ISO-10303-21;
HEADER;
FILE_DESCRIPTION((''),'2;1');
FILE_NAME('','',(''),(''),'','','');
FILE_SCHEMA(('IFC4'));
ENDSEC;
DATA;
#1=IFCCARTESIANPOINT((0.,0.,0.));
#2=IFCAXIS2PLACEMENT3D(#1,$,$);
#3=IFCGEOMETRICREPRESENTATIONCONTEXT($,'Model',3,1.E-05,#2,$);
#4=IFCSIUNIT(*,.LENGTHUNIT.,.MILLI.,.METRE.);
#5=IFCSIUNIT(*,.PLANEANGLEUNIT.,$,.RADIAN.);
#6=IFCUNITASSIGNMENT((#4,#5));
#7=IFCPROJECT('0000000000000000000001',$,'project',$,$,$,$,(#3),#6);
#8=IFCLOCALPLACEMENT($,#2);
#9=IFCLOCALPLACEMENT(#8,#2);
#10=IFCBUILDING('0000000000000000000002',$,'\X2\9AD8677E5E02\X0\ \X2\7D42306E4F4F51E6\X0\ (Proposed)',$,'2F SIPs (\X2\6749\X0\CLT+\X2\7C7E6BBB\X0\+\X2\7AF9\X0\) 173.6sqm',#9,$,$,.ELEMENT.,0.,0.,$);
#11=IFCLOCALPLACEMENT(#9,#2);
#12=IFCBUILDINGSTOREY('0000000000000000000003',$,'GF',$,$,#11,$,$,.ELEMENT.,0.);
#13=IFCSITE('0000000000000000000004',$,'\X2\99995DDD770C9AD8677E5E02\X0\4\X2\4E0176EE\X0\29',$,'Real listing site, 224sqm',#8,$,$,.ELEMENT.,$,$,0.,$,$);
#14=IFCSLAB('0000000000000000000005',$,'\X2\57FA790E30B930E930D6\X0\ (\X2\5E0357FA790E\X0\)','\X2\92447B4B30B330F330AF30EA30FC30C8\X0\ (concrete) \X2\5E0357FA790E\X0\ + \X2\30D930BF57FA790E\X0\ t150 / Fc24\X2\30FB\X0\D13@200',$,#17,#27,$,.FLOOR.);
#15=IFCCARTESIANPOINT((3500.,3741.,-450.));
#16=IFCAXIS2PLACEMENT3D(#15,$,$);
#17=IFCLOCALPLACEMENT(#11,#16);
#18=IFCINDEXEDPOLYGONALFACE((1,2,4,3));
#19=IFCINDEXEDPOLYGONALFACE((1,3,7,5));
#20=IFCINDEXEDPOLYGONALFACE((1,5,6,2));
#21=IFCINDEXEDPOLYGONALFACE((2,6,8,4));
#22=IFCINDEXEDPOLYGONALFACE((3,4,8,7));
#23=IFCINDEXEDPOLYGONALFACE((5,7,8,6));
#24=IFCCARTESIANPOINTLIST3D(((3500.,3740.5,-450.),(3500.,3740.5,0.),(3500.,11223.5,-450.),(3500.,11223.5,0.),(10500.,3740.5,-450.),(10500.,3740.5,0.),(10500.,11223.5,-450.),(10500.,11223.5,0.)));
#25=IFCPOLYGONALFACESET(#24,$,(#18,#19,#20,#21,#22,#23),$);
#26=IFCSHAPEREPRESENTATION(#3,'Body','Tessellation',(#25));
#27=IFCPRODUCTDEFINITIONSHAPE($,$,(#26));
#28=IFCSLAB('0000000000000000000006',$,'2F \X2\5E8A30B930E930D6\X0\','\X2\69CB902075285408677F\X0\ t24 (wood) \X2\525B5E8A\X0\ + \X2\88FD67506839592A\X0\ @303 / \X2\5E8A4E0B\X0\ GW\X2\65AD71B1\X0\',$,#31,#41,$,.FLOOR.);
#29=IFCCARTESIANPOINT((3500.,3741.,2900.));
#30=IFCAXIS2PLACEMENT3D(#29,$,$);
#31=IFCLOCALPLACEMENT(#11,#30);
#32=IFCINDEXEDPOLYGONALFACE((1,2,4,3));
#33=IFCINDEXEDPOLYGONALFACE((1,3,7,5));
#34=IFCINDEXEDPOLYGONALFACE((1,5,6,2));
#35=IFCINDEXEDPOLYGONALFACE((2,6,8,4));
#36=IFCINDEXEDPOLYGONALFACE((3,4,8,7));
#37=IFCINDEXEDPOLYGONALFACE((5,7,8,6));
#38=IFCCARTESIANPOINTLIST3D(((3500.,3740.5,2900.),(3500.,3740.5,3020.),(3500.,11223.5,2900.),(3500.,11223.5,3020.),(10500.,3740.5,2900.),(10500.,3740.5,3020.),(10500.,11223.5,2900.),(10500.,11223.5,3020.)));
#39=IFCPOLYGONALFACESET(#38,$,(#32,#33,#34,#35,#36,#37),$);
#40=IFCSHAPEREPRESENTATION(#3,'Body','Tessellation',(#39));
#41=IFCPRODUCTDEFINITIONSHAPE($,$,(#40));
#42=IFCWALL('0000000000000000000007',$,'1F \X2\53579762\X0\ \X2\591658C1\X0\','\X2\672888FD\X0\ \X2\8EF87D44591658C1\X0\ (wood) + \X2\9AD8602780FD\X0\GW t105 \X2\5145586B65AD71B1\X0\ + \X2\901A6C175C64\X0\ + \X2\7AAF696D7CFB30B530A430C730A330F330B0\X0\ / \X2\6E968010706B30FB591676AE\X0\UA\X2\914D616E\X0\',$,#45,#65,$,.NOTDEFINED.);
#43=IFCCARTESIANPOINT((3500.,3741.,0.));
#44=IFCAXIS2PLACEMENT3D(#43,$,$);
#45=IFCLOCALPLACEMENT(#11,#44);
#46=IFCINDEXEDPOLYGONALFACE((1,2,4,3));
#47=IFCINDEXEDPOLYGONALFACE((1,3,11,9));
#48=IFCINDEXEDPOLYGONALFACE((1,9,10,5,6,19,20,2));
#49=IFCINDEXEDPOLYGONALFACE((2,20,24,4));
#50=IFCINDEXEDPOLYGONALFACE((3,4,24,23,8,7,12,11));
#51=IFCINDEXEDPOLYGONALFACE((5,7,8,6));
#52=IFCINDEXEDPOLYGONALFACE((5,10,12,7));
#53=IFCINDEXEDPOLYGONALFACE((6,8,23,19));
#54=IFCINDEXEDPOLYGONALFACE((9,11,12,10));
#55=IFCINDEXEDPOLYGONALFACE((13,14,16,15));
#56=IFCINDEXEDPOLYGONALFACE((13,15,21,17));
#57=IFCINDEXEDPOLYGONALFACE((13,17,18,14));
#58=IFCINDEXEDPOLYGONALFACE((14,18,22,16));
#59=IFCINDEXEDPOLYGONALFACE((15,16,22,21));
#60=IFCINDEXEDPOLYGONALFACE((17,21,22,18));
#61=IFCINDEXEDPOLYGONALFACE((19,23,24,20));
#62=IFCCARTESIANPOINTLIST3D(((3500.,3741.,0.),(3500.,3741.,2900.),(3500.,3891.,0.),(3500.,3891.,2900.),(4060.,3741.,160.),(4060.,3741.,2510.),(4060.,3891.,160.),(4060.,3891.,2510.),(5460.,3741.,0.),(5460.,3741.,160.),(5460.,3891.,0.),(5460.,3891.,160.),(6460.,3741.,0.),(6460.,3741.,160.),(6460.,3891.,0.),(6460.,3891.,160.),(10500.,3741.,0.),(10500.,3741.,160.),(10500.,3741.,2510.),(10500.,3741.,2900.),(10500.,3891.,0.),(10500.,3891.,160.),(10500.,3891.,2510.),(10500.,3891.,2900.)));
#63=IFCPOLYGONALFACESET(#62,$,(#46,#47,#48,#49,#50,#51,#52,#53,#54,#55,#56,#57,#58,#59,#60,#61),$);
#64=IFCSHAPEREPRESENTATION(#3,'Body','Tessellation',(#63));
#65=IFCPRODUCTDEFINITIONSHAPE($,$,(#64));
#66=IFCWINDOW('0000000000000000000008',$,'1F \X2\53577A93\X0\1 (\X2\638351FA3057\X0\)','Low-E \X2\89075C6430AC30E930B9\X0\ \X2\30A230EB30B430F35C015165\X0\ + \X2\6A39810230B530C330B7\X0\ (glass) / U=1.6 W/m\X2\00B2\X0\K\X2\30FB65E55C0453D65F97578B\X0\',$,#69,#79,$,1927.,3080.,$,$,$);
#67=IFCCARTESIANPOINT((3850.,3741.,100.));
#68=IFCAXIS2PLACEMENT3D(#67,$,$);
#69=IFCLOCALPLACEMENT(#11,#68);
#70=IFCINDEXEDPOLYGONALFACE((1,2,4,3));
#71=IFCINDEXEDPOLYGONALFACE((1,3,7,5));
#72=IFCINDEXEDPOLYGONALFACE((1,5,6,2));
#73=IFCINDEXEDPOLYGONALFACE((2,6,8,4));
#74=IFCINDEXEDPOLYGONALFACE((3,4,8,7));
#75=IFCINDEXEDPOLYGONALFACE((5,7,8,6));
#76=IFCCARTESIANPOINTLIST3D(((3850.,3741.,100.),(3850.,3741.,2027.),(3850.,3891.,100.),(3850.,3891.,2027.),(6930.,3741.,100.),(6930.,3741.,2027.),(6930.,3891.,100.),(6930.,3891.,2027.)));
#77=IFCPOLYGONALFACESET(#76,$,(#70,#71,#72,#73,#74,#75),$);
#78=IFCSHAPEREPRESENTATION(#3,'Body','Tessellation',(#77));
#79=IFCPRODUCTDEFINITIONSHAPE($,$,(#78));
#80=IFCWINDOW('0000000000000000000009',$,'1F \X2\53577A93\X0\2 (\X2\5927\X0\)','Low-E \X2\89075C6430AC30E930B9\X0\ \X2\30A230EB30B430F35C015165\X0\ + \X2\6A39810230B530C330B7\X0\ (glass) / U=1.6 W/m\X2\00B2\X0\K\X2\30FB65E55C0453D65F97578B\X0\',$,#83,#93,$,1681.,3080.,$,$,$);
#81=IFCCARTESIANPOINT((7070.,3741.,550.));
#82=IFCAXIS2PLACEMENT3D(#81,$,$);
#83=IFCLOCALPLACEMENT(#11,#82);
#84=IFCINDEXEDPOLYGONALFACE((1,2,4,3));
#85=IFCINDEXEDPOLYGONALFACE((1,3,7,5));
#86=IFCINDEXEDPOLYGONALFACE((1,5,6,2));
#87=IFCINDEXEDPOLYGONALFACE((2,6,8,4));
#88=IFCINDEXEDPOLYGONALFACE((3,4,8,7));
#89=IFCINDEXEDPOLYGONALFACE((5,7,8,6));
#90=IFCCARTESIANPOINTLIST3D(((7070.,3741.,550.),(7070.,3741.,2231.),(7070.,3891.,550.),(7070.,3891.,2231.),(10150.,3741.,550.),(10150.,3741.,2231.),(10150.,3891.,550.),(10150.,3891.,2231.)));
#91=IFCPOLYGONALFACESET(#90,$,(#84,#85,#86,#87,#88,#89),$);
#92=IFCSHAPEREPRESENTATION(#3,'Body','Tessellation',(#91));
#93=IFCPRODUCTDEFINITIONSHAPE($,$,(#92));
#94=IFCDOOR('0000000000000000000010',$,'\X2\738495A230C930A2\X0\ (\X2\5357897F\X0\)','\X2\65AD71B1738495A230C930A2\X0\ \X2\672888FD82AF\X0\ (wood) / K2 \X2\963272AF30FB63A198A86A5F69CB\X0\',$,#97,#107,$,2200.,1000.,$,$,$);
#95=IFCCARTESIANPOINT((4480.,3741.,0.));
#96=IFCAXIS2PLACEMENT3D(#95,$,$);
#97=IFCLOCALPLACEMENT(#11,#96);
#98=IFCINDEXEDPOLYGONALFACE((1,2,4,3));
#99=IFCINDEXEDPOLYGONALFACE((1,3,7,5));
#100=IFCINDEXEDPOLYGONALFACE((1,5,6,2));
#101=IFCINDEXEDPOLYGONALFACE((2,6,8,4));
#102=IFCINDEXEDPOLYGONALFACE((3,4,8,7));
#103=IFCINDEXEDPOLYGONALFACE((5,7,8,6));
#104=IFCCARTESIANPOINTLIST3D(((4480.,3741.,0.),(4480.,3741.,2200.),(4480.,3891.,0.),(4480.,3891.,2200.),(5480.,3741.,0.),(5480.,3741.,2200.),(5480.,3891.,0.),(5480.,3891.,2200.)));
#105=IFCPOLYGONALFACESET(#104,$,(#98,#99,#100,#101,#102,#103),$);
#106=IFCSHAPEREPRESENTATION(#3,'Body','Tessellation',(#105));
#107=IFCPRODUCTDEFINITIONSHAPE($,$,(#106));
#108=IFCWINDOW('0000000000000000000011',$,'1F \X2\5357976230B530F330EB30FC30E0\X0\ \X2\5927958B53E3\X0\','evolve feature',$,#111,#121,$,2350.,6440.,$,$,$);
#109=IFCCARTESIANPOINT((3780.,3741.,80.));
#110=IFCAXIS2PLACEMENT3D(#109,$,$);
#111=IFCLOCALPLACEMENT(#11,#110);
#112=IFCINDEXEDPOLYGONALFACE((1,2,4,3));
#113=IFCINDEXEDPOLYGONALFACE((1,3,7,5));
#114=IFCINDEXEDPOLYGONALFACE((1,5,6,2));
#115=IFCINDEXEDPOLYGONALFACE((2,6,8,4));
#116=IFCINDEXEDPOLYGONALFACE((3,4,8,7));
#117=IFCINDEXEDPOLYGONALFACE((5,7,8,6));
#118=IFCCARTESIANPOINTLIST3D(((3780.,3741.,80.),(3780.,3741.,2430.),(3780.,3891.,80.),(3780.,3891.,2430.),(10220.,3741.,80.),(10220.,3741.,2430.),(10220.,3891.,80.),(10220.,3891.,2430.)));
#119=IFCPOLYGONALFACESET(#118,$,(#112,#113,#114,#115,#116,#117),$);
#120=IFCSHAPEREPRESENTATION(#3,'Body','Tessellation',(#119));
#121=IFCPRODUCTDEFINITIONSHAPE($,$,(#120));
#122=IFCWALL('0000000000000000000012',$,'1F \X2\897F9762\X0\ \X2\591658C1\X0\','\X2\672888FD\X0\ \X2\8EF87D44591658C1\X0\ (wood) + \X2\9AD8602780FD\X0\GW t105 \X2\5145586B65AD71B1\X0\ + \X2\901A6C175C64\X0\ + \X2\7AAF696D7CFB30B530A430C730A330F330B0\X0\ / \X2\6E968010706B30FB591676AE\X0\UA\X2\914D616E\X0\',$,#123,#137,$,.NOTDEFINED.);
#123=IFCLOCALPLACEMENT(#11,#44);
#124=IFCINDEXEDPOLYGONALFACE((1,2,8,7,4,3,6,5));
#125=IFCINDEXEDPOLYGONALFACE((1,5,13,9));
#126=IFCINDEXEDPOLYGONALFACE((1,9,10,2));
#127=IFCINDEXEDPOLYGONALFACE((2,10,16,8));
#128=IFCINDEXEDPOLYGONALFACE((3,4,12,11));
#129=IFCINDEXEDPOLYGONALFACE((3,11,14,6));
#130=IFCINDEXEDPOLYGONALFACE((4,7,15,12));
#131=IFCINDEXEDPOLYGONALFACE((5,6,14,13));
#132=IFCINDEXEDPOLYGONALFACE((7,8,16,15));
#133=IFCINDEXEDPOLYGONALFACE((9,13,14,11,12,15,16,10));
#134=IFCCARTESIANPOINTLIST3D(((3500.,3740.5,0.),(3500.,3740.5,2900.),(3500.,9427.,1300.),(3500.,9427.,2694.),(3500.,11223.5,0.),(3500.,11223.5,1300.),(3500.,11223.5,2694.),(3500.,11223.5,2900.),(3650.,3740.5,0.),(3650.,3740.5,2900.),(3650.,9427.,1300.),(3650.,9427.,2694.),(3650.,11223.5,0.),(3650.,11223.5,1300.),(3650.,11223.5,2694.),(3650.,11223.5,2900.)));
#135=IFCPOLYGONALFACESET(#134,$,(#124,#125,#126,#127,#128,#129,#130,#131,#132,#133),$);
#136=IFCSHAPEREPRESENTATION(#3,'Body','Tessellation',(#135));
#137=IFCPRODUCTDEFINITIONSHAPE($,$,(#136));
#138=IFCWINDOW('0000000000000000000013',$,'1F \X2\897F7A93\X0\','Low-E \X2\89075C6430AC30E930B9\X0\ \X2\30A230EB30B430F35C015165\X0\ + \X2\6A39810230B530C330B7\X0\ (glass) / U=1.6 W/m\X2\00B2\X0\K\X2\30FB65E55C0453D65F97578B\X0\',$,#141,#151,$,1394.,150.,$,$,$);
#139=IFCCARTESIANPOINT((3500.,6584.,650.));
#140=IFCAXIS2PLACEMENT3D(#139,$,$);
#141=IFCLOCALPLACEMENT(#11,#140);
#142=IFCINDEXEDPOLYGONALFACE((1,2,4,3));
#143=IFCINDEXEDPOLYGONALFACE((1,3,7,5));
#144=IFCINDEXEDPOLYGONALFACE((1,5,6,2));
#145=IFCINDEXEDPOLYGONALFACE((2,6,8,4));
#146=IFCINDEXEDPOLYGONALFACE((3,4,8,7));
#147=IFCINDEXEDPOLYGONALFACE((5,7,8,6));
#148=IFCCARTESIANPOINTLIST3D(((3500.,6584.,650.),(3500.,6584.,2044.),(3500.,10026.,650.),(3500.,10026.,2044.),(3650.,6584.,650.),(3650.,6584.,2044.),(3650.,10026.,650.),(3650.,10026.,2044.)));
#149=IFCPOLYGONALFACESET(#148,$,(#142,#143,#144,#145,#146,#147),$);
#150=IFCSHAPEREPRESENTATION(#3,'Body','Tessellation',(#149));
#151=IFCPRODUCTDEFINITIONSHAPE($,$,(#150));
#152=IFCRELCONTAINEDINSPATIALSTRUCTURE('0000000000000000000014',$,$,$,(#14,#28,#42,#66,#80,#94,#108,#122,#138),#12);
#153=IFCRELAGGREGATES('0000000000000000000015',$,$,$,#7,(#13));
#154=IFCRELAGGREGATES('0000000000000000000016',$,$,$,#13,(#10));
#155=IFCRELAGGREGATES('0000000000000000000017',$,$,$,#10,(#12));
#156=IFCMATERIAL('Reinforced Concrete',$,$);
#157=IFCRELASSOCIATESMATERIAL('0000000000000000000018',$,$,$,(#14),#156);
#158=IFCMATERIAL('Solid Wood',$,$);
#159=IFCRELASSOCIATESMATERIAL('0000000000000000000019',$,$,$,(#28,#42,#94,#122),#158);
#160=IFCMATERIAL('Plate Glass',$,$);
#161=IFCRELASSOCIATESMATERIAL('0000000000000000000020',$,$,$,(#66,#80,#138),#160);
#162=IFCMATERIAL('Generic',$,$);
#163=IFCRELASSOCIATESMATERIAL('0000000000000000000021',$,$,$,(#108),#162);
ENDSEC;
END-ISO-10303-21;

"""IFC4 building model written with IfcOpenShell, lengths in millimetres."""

from ifc_helpers import new_model, si_unit, frame, frame_2d, origin, place, context, project, spatial, rectangle, extrude, material, element, fill, save


model = new_model("IFC4")

# Units and contexts
model_context = context("Model", 3, precision=1e-05, world=origin())
ifc_project = project(units=[si_unit("LENGTHUNIT", "METRE", prefix="MILLI"), si_unit("PLANEANGLEUNIT", "RADIAN")], contexts=[model_context])

# Site, building, storey
site_placement = place(None, origin())
site = spatial("IfcSite", under=ifc_project, at=site_placement, Name="香川県高松市4丁目29", ObjectType="Real listing site, 224sqm", CompositionType="ELEMENT", RefElevation=0.0)
building_placement = place(site_placement, origin())
building = spatial("IfcBuilding", under=site, at=building_placement, Name="高松市 終の住処 (Proposed)", ObjectType="2F SIPs (杉CLT+籾殻+竹) 173.6sqm", CompositionType="ELEMENT", ElevationOfRefHeight=0.0, ElevationOfTerrain=0.0)
storey_placement = place(building_placement, origin())
storey = spatial("IfcBuildingStorey", under=building, at=storey_placement, Name="GF", CompositionType="ELEMENT", Elevation=0.0)

# Slabs
ifc_material_1 = material(Name="Reinforced Concrete")
slab_1_placement = place(storey_placement, frame((3500.0, 3741.0, -450.0)))
element("IfcSlab", 1, at=slab_1_placement, inside=storey, material=ifc_material_1, Name="基礎スラブ (布基礎)", Description="鉄筋コンクリート (concrete) 布基礎 + ベタ基礎 t150 / Fc24・D13@200", PredefinedType="FLOOR", context=model_context, shape_type="SweptSolid", body=[
    extrude(rectangle(XDim=7000.0, YDim=7483.0, at=frame_2d((3500.0, 3741.0))), frame((3500.0, 3741.0, -450.0)), (0.0, 0.0, 1.0), 450.0),
])
ifc_material_2 = material(Name="Solid Wood")
slab_2_placement = place(storey_placement, frame((3500.0, 3741.0, 2900.0)))
element("IfcSlab", 2, at=slab_2_placement, inside=storey, material=ifc_material_2, Name="2F 床スラブ", Description="構造用合板 t24 (wood) 剛床 + 製材根太 @303 / 床下 GW断熱", PredefinedType="FLOOR", context=model_context, shape_type="SweptSolid", body=[
    extrude(rectangle(XDim=7000.0, YDim=7483.0, at=frame_2d((3500.0, 3741.0))), frame((3500.0, 3741.0, 2900.0)), (0.0, 0.0, 1.0), 120.0),
])
ifc_material_3 = material(Name="Generic")

# Wall, openings, windows, door
wall_1_placement = place(storey_placement, frame((3500.0, 3741.0, 0.0)))
wall_1 = element("IfcWall", 3, at=wall_1_placement, inside=storey, material=ifc_material_2, Name="1F 南面 外壁", Description="木製 軸組外壁 (wood) + 高性能GW t105 充填断熱 + 通気層 + 窯業系サイディング / 準耐火・外皮UA配慮", PredefinedType="NOTDEFINED", context=model_context, shape_type="SweptSolid", body=[
    extrude(rectangle(XDim=7000.0, YDim=150.0, at=frame_2d((3500.0, 75.0))), frame((3500.0, 3741.0, 0.0)), (0.0, 0.0, 1.0), 2900.0),
])
opening_1_placement = place(storey_placement, frame((3850.0, 3741.0, 100.0)))
opening_1 = element("IfcOpeningElement", 4, at=opening_1_placement, cuts=wall_1, PredefinedType="NOTDEFINED", context=model_context, shape_type="SweptSolid", body=[
    extrude(rectangle(XDim=3080.0, YDim=150.0, at=frame_2d((1540.0, 75.0))), frame((3850.0, 3741.0, 100.0)), (0.0, 0.0, 1.0), 1927.0),
])
opening_2_placement = place(storey_placement, frame((7070.0, 3741.0, 550.0)))
opening_2 = element("IfcOpeningElement", 5, at=opening_2_placement, cuts=wall_1, PredefinedType="NOTDEFINED", context=model_context, shape_type="SweptSolid", body=[
    extrude(rectangle(XDim=3080.0, YDim=150.0, at=frame_2d((1540.0, 75.0))), frame((7070.0, 3741.0, 550.0)), (0.0, 0.0, 1.0), 1681.0),
])
opening_3_placement = place(storey_placement, frame((4480.0, 3741.0, 0.0)))
opening_3 = element("IfcOpeningElement", 6, at=opening_3_placement, cuts=wall_1, PredefinedType="NOTDEFINED", context=model_context, shape_type="SweptSolid", body=[
    extrude(rectangle(XDim=1000.0, YDim=150.0, at=frame_2d((500.0, 75.0))), frame((4480.0, 3741.0, 0.0)), (0.0, 0.0, 1.0), 2200.0),
])
opening_4_placement = place(storey_placement, frame((3780.0, 3741.0, 80.0)))
opening_4 = element("IfcOpeningElement", 7, at=opening_4_placement, cuts=wall_1, PredefinedType="NOTDEFINED", context=model_context, shape_type="SweptSolid", body=[
    extrude(rectangle(XDim=6440.0, YDim=150.0, at=frame_2d((3220.0, 75.0))), frame((3780.0, 3741.0, 80.0)), (0.0, 0.0, 1.0), 2350.0),
])
ifc_material_4 = material(Name="Plate Glass")
window_1_placement = place(storey_placement, frame((3850.0, 3741.0, 100.0)))
window_1 = element("IfcWindow", 8, at=window_1_placement, inside=storey, material=ifc_material_4, Name="1F 南窓1 (掃出し)", Description="Low-E 複層ガラス アルゴン封入 + 樹脂サッシ (glass) / U=1.6 W/m²K・日射取得型", OverallHeight=1927.0, OverallWidth=3080.0, context=model_context, shape_type="SweptSolid", body=[
    extrude(rectangle(XDim=3080.0, YDim=150.0, at=frame_2d((1540.0, 75.0))), frame((3850.0, 3741.0, 100.0)), (0.0, 0.0, 1.0), 1927.0),
])
fill(opening_1, window_1)
window_2_placement = place(storey_placement, frame((7070.0, 3741.0, 550.0)))
window_2 = element("IfcWindow", 9, at=window_2_placement, inside=storey, material=ifc_material_4, Name="1F 南窓2 (大)", Description="Low-E 複層ガラス アルゴン封入 + 樹脂サッシ (glass) / U=1.6 W/m²K・日射取得型", OverallHeight=1681.0, OverallWidth=3080.0, context=model_context, shape_type="SweptSolid", body=[
    extrude(rectangle(XDim=3080.0, YDim=150.0, at=frame_2d((1540.0, 75.0))), frame((7070.0, 3741.0, 550.0)), (0.0, 0.0, 1.0), 1681.0),
])
fill(opening_2, window_2)
door_placement = place(storey_placement, frame((4480.0, 3741.0, 0.0)))
door = element("IfcDoor", 10, at=door_placement, inside=storey, material=ifc_material_2, Name="玄関ドア (南西)", Description="断熱玄関ドア 木製芯 (wood) / K2 防犯・採風機構", OverallHeight=2200.0, OverallWidth=1000.0, context=model_context, shape_type="SweptSolid", body=[
    extrude(rectangle(XDim=1000.0, YDim=150.0, at=frame_2d((500.0, 75.0))), frame((4480.0, 3741.0, 0.0)), (0.0, 0.0, 1.0), 2200.0),
])
fill(opening_3, door)
window_3_placement = place(storey_placement, frame((3780.0, 3741.0, 80.0)))
window_3 = element("IfcWindow", 11, at=window_3_placement, inside=storey, material=ifc_material_3, Name="1F 南面サンルーム 大開口", Description="evolve feature", OverallHeight=2350.0, OverallWidth=6440.0, context=model_context, shape_type="SweptSolid", body=[
    extrude(rectangle(XDim=6440.0, YDim=150.0, at=frame_2d((3220.0, 75.0))), frame((3780.0, 3741.0, 80.0)), (0.0, 0.0, 1.0), 2350.0),
])
fill(opening_4, window_3)

# Wall, opening, window
wall_2_placement = place(storey_placement, frame((3500.0, 3741.0, 0.0)))
wall_2 = element("IfcWall", 12, at=wall_2_placement, inside=storey, material=ifc_material_2, Name="1F 西面 外壁", Description="木製 軸組外壁 (wood) + 高性能GW t105 充填断熱 + 通気層 + 窯業系サイディング / 準耐火・外皮UA配慮", PredefinedType="NOTDEFINED", context=model_context, shape_type="SweptSolid", body=[
    extrude(rectangle(XDim=150.0, YDim=7483.0, at=frame_2d((75.0, 3741.0))), frame((3500.0, 3741.0, 0.0)), (0.0, 0.0, 1.0), 2900.0),
])
opening_5_placement = place(storey_placement, frame((3500.0, 6584.0, 650.0)))
opening_5 = element("IfcOpeningElement", 13, at=opening_5_placement, cuts=wall_2, PredefinedType="NOTDEFINED", context=model_context, shape_type="SweptSolid", body=[
    extrude(rectangle(XDim=150.0, YDim=3442.0, at=frame_2d((75.0, 1721.0))), frame((3500.0, 6584.0, 650.0)), (0.0, 0.0, 1.0), 1394.0),
])
window_4_placement = place(storey_placement, frame((3500.0, 6584.0, 650.0)))
window_4 = element("IfcWindow", 14, at=window_4_placement, inside=storey, material=ifc_material_4, Name="1F 西窓", Description="Low-E 複層ガラス アルゴン封入 + 樹脂サッシ (glass) / U=1.6 W/m²K・日射取得型", OverallHeight=1394.0, OverallWidth=150.0, context=model_context, shape_type="SweptSolid", body=[
    extrude(rectangle(XDim=150.0, YDim=3442.0, at=frame_2d((75.0, 1721.0))), frame((3500.0, 6584.0, 650.0)), (0.0, 0.0, 1.0), 1394.0),
])
fill(opening_5, window_4)

save(model, "model.ifc")
